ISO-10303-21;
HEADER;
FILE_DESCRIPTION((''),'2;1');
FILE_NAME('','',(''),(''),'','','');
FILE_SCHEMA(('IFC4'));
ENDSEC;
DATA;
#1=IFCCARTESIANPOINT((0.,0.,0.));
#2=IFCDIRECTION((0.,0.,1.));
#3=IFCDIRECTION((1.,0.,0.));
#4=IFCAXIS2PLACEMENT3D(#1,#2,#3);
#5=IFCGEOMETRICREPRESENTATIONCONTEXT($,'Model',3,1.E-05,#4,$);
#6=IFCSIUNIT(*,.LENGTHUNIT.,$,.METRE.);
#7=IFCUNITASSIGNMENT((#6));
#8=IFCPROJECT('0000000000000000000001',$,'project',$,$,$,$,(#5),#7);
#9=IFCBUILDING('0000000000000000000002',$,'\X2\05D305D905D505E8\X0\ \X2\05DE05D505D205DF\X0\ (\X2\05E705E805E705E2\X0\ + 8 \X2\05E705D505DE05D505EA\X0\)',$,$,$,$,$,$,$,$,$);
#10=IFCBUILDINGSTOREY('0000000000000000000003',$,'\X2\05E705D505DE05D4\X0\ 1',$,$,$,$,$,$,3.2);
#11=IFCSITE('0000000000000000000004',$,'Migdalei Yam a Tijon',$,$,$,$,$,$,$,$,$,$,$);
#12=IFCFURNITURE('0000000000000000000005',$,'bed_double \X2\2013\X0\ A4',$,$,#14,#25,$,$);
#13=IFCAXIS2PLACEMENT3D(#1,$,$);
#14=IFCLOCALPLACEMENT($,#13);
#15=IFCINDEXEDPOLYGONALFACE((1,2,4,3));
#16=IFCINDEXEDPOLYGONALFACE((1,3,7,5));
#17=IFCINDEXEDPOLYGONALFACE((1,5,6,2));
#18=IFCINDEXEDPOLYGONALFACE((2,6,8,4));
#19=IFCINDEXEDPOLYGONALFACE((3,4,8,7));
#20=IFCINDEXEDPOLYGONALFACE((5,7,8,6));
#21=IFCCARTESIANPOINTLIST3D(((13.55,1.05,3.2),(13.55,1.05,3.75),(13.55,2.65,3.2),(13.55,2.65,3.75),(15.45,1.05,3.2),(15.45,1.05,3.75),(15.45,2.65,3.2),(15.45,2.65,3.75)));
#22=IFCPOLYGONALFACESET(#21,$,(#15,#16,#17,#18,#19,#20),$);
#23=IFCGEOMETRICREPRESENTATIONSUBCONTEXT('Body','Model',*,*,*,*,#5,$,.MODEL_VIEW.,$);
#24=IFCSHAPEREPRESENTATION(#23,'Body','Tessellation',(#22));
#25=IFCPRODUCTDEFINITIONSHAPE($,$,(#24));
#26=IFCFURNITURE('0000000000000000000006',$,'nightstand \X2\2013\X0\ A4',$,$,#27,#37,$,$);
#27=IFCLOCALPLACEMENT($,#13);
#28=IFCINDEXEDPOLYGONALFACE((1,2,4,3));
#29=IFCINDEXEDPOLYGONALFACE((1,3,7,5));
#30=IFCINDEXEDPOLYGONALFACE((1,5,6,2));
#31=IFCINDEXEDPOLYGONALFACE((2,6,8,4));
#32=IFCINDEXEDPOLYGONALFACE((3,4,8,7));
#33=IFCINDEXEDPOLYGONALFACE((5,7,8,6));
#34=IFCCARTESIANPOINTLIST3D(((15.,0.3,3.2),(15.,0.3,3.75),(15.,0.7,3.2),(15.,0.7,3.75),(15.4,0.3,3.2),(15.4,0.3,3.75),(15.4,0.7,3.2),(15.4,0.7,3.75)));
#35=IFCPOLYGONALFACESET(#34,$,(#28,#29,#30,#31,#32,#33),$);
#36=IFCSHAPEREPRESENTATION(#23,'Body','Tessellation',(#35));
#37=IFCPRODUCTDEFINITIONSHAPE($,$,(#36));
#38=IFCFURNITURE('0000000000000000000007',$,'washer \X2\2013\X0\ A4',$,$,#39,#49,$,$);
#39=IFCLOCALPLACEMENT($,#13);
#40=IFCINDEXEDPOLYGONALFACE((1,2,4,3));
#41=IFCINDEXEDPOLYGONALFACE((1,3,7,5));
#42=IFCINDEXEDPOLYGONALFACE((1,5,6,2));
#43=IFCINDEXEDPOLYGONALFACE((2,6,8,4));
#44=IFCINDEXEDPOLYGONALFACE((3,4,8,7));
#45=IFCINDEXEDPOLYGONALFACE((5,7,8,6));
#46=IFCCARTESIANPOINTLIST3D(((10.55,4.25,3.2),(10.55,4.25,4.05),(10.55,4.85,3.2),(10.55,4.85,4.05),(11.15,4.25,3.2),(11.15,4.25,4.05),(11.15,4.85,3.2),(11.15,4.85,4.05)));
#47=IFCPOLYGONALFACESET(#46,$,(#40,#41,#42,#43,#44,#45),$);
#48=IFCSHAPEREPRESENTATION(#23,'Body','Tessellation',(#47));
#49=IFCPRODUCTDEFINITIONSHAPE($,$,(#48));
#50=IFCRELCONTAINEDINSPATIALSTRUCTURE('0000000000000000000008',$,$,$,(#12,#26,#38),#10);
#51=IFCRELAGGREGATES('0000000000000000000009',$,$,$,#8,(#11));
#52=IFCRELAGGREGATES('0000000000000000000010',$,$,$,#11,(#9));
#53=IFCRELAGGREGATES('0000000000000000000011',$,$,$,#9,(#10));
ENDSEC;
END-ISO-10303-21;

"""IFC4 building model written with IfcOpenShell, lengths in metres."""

from ifc_helpers import new_model, si_unit, frame, origin_with_axes, context, subcontext, project, spatial, line, indexed_curve, outline, extrude, element, save


model = new_model("IFC4")

# Units and contexts
model_context = context("Model", 3, precision=1e-05, world=origin_with_axes())
body_context = subcontext(model_context, "Body", "Model", "MODEL_VIEW")
ifc_project = project(units=[si_unit("LENGTHUNIT", "METRE")], contexts=[model_context])

# Site, building, storey
site = spatial("IfcSite", under=ifc_project, Name="Migdalei Yam a Tijon")
building = spatial("IfcBuilding", under=site, Name="דיור מוגן (קרקע + 8 קומות)")
storey = spatial("IfcBuildingStorey", under=building, Name="קומה 1", Elevation=3.2)

# Furniture
element("IfcFurniture", 1, inside=storey, Name="bed_double – A4", context=body_context, shape_type="SweptSolid", body=[
    extrude(outline(indexed_curve([(0.0, 0.0), (1.9, 0.0), (1.9, 1.6), (0.0, 1.6)], segments=[line(1, 2, 3, 4, 1)])), frame((13.55, 1.05, 3.2), z_axis=(0.0, 0.0, 1.0), x_axis=(1.0, 0.0, 0.0)), (0.0, 0.0, 1.0), 0.55),
])
element("IfcFurniture", 2, inside=storey, Name="nightstand – A4", context=body_context, shape_type="SweptSolid", body=[
    extrude(outline(indexed_curve([(0.0, 0.0), (0.4, 0.0), (0.4, 0.4), (0.0, 0.4)], segments=[line(1, 2, 3, 4, 1)])), frame((15.0, 0.3, 3.2), z_axis=(0.0, 0.0, 1.0), x_axis=(1.0, 0.0, 0.0)), (0.0, 0.0, 1.0), 0.55),
])
element("IfcFurniture", 3, inside=storey, Name="washer – A4", context=body_context, shape_type="SweptSolid", body=[
    extrude(outline(indexed_curve([(0.0, 0.0), (0.6, 0.0), (0.6, 0.6), (0.0, 0.6)], segments=[line(1, 2, 3, 4, 1)])), frame((10.55, 4.25, 3.2), z_axis=(0.0, 0.0, 1.0), x_axis=(1.0, 0.0, 0.0)), (0.0, 0.0, 1.0), 0.85),
])

save(model, "model.ifc")
